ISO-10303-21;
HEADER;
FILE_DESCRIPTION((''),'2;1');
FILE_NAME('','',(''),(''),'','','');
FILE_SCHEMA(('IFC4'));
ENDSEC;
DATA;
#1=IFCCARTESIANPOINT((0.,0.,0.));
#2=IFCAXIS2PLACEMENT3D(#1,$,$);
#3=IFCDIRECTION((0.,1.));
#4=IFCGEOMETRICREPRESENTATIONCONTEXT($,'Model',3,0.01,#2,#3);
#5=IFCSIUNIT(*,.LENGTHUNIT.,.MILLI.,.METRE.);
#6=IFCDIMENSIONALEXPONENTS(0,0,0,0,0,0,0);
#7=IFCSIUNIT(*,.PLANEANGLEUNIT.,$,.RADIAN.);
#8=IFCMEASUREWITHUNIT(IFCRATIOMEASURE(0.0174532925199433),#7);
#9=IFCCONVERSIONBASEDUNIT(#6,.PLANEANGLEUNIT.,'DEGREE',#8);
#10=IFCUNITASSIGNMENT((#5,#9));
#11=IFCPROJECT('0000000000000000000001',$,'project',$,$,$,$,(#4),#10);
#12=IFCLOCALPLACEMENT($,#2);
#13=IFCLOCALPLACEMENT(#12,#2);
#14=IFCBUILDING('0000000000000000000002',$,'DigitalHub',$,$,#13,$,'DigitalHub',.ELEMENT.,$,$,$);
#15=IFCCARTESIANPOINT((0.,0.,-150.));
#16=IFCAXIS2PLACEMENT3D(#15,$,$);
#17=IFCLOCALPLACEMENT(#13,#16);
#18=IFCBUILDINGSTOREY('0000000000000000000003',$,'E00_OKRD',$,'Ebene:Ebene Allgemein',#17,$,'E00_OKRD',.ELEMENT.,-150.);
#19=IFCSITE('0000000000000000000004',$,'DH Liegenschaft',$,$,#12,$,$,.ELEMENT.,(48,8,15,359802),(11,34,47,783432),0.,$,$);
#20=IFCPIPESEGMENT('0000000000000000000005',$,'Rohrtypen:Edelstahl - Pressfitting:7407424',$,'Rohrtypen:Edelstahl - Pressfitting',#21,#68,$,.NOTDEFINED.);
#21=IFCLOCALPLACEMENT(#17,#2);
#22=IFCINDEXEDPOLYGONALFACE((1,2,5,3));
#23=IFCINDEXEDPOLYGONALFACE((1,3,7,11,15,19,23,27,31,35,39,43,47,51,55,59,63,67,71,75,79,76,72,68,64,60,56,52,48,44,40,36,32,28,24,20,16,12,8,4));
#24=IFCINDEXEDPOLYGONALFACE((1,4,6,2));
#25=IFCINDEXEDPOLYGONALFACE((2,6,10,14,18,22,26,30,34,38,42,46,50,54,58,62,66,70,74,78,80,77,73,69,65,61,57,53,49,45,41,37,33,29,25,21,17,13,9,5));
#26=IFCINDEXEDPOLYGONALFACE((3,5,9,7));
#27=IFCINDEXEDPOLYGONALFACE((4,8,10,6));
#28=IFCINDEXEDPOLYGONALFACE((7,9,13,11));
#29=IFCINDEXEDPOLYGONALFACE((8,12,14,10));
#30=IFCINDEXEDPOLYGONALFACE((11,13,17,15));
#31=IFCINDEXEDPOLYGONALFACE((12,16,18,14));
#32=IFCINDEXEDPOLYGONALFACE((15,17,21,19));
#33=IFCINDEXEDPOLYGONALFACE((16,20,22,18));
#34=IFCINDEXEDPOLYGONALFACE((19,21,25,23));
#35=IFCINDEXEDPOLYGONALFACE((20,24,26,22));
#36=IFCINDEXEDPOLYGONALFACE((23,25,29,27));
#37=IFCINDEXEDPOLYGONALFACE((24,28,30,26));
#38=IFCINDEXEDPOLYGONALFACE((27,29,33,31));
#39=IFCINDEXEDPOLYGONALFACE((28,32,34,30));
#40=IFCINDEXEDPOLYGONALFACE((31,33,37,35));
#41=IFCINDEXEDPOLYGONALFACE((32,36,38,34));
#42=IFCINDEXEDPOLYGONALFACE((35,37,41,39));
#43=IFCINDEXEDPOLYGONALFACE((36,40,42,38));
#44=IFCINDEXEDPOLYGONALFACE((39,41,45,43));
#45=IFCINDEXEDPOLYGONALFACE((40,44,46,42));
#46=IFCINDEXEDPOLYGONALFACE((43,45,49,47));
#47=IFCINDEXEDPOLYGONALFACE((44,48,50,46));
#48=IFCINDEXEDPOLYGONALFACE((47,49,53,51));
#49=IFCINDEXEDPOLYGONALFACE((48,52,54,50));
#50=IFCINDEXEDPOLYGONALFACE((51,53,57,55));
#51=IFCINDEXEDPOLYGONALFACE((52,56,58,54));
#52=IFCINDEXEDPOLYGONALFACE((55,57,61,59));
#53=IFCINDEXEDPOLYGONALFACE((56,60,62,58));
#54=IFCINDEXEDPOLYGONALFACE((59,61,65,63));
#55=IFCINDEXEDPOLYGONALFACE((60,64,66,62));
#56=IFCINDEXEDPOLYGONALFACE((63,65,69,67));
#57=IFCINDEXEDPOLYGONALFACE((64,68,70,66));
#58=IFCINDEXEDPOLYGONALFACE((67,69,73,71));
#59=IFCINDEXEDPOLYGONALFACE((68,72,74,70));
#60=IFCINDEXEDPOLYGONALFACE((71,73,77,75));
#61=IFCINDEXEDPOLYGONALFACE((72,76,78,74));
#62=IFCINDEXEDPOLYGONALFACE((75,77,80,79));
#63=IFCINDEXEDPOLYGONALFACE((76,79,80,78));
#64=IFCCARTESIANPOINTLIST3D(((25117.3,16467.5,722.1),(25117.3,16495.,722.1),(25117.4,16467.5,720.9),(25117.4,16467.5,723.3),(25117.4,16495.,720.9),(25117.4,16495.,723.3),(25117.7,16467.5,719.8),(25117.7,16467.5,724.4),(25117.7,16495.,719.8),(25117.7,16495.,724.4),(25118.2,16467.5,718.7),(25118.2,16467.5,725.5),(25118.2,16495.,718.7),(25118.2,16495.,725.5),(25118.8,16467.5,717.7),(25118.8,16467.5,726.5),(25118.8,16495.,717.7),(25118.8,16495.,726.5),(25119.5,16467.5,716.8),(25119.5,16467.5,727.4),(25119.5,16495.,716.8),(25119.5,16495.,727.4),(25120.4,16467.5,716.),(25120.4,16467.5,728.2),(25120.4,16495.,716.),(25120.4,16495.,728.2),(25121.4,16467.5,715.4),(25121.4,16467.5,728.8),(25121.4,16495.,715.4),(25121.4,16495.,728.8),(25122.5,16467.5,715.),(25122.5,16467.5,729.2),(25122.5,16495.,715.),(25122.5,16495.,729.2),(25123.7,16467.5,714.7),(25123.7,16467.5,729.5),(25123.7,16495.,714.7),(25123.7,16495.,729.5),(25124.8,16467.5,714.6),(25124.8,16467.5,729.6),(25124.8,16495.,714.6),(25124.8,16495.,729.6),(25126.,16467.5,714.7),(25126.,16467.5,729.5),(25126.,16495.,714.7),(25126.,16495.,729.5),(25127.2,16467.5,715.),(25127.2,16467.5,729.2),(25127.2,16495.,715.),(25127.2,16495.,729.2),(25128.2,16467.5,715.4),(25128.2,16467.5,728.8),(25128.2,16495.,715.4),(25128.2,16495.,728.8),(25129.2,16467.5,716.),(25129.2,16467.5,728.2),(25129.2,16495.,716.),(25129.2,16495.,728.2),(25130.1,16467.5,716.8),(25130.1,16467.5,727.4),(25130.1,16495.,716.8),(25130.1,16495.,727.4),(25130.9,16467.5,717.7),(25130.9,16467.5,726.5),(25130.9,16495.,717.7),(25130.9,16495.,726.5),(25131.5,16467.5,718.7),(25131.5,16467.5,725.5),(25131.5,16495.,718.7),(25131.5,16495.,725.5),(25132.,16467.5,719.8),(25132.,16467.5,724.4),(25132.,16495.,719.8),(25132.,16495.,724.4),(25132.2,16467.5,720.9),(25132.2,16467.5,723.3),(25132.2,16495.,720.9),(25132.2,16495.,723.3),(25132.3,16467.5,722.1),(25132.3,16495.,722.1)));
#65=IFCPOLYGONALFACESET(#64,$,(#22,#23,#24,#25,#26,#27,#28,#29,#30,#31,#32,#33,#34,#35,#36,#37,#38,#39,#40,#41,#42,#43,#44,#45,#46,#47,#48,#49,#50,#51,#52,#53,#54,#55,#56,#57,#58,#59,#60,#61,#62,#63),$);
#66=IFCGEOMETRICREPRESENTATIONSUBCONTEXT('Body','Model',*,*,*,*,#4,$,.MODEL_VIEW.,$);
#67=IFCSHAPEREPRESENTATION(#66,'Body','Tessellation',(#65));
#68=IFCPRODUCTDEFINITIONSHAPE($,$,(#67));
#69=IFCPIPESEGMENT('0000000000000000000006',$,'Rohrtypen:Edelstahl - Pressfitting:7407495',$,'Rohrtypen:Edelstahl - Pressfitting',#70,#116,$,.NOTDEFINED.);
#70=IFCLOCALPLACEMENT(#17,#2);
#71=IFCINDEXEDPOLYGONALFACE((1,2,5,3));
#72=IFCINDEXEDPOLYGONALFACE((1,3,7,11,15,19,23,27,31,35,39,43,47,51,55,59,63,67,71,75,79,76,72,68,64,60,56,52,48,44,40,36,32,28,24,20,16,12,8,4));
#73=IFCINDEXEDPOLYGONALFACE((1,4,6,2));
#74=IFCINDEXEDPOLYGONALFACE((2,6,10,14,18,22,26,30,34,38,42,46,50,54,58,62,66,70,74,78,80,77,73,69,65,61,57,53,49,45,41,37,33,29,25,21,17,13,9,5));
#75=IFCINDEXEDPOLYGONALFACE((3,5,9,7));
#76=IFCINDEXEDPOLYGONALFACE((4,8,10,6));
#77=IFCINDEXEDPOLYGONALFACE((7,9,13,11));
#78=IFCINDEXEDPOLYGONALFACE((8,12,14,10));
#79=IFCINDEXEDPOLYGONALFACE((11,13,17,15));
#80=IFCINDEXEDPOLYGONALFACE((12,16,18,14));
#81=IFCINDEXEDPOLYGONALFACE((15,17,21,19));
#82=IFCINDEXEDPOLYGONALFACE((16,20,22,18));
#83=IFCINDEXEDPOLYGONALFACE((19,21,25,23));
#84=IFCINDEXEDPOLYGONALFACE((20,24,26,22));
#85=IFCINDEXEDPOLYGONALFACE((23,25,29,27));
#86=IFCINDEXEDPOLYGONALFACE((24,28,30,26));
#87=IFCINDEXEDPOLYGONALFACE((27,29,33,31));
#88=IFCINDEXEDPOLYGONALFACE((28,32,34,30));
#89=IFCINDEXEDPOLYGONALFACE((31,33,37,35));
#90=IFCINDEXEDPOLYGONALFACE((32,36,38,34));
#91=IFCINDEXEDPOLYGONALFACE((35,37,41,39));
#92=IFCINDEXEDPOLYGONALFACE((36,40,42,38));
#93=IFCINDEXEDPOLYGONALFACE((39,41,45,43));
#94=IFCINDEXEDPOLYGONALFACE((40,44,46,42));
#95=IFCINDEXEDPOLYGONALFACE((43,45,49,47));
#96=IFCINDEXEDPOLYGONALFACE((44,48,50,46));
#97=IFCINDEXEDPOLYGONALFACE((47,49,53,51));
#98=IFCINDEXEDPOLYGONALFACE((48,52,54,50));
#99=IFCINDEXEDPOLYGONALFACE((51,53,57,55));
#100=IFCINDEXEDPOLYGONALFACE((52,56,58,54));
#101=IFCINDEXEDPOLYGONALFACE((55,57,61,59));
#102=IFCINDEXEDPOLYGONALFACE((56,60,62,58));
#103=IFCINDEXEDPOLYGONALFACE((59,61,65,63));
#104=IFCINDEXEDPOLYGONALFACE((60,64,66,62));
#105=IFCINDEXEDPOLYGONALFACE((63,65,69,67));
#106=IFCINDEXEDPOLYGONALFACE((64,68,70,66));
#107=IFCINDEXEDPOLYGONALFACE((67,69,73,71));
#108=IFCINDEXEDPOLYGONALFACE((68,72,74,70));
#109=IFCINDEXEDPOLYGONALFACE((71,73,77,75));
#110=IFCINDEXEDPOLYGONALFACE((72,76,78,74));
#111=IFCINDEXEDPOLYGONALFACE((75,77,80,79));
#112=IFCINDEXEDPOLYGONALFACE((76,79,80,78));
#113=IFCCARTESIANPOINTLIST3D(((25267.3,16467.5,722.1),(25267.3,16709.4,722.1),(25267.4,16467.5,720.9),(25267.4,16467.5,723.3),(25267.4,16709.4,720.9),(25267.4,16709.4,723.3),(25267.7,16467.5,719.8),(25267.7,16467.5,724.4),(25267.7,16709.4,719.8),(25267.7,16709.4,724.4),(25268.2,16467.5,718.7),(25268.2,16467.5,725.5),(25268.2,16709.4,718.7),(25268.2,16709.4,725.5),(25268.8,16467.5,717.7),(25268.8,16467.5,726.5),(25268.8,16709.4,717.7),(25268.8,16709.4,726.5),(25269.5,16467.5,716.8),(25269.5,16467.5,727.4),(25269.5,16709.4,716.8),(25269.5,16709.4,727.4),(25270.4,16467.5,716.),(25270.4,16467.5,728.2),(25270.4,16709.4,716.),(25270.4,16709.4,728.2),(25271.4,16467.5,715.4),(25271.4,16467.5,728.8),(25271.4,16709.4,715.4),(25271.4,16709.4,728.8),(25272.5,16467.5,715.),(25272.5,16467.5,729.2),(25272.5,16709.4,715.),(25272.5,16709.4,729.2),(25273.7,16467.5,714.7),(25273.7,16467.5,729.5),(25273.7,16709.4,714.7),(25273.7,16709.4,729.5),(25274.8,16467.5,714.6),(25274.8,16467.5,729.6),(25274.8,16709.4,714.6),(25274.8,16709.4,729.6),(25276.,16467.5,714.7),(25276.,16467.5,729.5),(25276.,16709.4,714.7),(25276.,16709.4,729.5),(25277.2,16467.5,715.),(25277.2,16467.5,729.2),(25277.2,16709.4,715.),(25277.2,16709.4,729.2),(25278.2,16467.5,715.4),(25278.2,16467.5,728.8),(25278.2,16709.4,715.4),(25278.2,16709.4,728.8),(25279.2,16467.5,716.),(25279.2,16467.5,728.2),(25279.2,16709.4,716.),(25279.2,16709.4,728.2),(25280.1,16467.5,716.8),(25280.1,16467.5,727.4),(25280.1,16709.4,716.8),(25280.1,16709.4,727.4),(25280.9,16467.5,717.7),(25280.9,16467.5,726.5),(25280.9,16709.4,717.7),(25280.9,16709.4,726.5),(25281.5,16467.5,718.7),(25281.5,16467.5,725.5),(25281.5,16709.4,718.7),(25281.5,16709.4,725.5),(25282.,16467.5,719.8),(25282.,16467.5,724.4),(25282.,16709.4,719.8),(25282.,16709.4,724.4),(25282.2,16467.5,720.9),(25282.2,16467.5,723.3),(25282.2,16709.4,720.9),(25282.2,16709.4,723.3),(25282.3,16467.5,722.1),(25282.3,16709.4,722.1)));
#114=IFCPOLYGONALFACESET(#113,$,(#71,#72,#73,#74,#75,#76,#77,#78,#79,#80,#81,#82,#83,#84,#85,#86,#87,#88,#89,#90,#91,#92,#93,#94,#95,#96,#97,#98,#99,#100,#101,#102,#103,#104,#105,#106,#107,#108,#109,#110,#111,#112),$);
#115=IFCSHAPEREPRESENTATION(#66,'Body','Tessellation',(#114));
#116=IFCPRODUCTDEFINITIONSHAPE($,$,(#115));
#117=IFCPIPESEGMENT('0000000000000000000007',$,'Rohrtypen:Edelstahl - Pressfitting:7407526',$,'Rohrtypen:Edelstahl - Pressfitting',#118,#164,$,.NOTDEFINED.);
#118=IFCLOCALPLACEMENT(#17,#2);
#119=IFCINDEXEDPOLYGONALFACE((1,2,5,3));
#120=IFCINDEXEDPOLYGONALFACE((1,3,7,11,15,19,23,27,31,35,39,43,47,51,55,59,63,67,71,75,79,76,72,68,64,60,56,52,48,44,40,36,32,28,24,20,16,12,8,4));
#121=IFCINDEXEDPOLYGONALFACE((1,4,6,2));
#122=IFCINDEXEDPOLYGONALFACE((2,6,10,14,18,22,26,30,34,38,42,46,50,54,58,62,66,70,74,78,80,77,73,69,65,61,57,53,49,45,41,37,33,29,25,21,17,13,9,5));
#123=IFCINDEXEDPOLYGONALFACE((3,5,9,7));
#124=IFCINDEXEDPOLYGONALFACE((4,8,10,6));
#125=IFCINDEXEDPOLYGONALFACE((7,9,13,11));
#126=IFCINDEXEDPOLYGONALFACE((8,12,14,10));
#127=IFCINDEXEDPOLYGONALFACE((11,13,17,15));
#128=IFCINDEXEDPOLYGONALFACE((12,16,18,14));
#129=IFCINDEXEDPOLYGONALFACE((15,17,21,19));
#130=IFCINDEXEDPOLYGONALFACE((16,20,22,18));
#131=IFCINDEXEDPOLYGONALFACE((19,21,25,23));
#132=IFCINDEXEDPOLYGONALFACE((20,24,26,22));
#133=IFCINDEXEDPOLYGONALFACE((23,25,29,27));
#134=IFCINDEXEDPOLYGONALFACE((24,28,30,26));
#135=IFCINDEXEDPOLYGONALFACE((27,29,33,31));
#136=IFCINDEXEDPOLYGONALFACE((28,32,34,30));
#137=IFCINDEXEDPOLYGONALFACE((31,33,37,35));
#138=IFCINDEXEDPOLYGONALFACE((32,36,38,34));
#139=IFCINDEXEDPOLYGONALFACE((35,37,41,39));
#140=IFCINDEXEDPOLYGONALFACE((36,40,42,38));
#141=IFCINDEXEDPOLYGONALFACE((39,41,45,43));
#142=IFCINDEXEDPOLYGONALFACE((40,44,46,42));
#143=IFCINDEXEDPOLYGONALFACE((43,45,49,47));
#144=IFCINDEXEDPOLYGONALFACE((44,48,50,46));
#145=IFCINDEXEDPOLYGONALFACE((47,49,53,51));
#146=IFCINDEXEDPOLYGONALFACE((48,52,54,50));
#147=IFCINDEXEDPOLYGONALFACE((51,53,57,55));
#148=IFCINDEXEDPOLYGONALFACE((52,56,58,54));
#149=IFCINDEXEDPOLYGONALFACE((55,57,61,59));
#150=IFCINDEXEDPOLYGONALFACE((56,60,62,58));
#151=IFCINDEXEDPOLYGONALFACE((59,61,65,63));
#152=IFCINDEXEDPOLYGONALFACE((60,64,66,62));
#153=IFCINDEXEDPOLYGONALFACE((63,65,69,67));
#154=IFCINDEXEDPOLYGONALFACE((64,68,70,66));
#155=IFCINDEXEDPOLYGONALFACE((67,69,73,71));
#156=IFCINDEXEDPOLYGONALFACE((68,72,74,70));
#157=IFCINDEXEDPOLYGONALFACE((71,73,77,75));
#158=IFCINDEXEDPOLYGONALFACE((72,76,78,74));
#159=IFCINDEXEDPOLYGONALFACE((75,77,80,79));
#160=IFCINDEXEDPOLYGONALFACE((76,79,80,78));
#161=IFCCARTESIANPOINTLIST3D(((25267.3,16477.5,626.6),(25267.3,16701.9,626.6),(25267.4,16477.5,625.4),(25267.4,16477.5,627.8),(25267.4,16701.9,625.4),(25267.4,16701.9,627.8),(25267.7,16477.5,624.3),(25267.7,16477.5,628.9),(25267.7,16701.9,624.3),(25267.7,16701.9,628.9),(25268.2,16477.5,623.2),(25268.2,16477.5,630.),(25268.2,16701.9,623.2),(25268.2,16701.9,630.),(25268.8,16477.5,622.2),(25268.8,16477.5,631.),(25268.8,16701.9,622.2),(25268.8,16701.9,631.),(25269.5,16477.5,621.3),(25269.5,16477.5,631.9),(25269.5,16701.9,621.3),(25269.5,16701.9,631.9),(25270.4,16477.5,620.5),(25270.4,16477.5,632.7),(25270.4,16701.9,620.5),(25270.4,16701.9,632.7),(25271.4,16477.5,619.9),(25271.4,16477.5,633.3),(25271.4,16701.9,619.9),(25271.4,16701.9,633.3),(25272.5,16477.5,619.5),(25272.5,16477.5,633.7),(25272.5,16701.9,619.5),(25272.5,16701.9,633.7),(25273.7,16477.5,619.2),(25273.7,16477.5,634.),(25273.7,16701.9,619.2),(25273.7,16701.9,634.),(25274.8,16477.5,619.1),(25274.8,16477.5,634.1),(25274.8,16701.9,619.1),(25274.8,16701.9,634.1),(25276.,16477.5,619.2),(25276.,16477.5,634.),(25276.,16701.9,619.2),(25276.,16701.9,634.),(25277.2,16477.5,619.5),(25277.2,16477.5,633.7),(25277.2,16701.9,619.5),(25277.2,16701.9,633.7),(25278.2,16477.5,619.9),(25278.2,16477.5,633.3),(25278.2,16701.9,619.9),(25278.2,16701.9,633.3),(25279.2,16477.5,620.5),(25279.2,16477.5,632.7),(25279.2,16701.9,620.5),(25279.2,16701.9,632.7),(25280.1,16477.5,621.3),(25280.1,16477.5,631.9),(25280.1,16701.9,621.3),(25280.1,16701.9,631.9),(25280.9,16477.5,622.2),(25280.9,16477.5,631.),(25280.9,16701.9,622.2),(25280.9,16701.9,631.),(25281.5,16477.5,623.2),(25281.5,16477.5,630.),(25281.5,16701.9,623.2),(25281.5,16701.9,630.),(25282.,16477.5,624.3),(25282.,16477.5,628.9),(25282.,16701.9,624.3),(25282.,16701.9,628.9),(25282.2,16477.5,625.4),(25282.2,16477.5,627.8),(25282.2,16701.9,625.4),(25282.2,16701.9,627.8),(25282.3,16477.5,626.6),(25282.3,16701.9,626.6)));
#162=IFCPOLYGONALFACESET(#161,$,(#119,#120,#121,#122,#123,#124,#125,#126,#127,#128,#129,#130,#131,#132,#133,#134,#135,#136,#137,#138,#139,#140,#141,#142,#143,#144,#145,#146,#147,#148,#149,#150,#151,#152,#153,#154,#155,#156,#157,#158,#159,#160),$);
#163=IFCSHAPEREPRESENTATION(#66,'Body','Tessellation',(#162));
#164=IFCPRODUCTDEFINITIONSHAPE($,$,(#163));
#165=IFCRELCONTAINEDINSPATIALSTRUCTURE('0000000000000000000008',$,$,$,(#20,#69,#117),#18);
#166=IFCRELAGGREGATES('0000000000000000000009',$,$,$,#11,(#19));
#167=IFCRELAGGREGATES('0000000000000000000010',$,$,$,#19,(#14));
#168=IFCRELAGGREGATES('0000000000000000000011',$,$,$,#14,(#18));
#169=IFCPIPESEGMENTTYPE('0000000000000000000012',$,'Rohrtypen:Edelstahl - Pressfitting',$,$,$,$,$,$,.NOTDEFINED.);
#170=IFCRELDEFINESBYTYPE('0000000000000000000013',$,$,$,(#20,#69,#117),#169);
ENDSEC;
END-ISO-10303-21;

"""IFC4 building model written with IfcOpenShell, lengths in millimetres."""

from ifc_helpers import new_model, entity, si_unit, converted_unit, direction, frame, origin, place, context, subcontext, project, spatial, indexed_curve, outline, extrude, type_object, element, save


model = new_model("IFC4")

# Units and contexts
model_context = context("Model", 3, precision=0.01, world=origin(), true_north=direction((0.0, 1.0)))
body_context = subcontext(model_context, "Body", "Model", "MODEL_VIEW")
ifc_project = project(units=[si_unit("LENGTHUNIT", "METRE", prefix="MILLI"), converted_unit("PLANEANGLEUNIT", "DEGREE", entity("IfcRatioMeasure", 0.0174532925199433), si_unit("PLANEANGLEUNIT", "RADIAN"), dimensions=[0, 0, 0, 0, 0, 0, 0])], contexts=[model_context])

# Site, building, storey
site_placement = place(None, origin())
site = spatial("IfcSite", under=ifc_project, at=site_placement, Name="DH Liegenschaft", CompositionType="ELEMENT", RefLatitude=(48, 8, 15, 359802), RefLongitude=(11, 34, 47, 783432), RefElevation=0.0)
building_placement = place(site_placement, origin())
building = spatial("IfcBuilding", under=site, at=building_placement, Name="DigitalHub", LongName="DigitalHub", CompositionType="ELEMENT")
storey_placement = place(building_placement, frame((0.0, 0.0, -150.0)))
storey = spatial("IfcBuildingStorey", under=building, at=storey_placement, Name="E00_OKRD", ObjectType="Ebene:Ebene Allgemein", LongName="E00_OKRD", CompositionType="ELEMENT", Elevation=-150.0)

# Pipe segments
pipe_segment_type_1 = type_object("IfcPipeSegmentType", Name="Rohrtypen:Edelstahl - Pressfitting", PredefinedType="NOTDEFINED")
pipe_segment_1_placement = place(storey_placement, frame((25115.7, 16467.5, 713.0)))
element("IfcPipeSegment", 1, at=pipe_segment_1_placement, inside=storey, type_object=pipe_segment_type_1, Name="Rohrtypen:Edelstahl - Pressfitting:7407424", ObjectType="Rohrtypen:Edelstahl - Pressfitting", PredefinedType="NOTDEFINED", context=body_context, shape_type="SweptSolid", body=[
    extrude(outline(indexed_curve([(7.5, 0.0), (7.4, 1.2), (7.1, 2.3), (6.7, 3.4), (6.1, 4.4), (5.3, 5.3), (4.4, 6.1), (3.4, 6.7), (2.3, 7.1), (1.2, 7.4), (0.0, 7.5), (-1.2, 7.4), (-2.3, 7.1), (-3.4, 6.7), (-4.4, 6.1), (-5.3, 5.3), (-6.1, 4.4), (-6.7, 3.4), (-7.1, 2.3), (-7.4, 1.2), (-7.5, 0.0), (-7.4, -1.2), (-7.1, -2.3), (-6.7, -3.4), (-6.1, -4.4), (-5.3, -5.3), (-4.4, -6.1), (-3.4, -6.7), (-2.3, -7.1), (-1.2, -7.4), (0.0, -7.5), (1.2, -7.4), (2.3, -7.1), (3.4, -6.7), (4.4, -6.1), (5.3, -5.3), (6.1, -4.4), (6.7, -3.4), (7.1, -2.3), (7.4, -1.2), (7.5, 0.0)], self_intersect=False)), frame((9.1, 0.0, 9.1), z_axis=(0.0, 1.0, 0.0), x_axis=(1.0, 0.0, 0.0)), (0.0, 0.0, 1.0), 27.4),
])
pipe_segment_2_placement = place(storey_placement, frame((25265.7, 16467.5, 713.0)))
element("IfcPipeSegment", 2, at=pipe_segment_2_placement, inside=storey, type_object=pipe_segment_type_1, Name="Rohrtypen:Edelstahl - Pressfitting:7407495", ObjectType="Rohrtypen:Edelstahl - Pressfitting", PredefinedType="NOTDEFINED", context=body_context, shape_type="SweptSolid", body=[
    extrude(outline(indexed_curve([(7.5, 0.0), (7.4, 1.2), (7.1, 2.3), (6.7, 3.4), (6.1, 4.4), (5.3, 5.3), (4.4, 6.1), (3.4, 6.7), (2.3, 7.1), (1.2, 7.4), (0.0, 7.5), (-1.2, 7.4), (-2.3, 7.1), (-3.4, 6.7), (-4.4, 6.1), (-5.3, 5.3), (-6.1, 4.4), (-6.7, 3.4), (-7.1, 2.3), (-7.4, 1.2), (-7.5, 0.0), (-7.4, -1.2), (-7.1, -2.3), (-6.7, -3.4), (-6.1, -4.4), (-5.3, -5.3), (-4.4, -6.1), (-3.4, -6.7), (-2.3, -7.1), (-1.2, -7.4), (0.0, -7.5), (1.2, -7.4), (2.3, -7.1), (3.4, -6.7), (4.4, -6.1), (5.3, -5.3), (6.1, -4.4), (6.7, -3.4), (7.1, -2.3), (7.4, -1.2), (7.5, 0.0)], self_intersect=False)), frame((9.1, 0.0, 9.1), z_axis=(0.0, 1.0, 0.0), x_axis=(1.0, 0.0, 0.0)), (0.0, 0.0, 1.0), 241.9),
])
pipe_segment_3_placement = place(storey_placement, frame((25265.7, 16477.5, 617.5)))
element("IfcPipeSegment", 3, at=pipe_segment_3_placement, inside=storey, type_object=pipe_segment_type_1, Name="Rohrtypen:Edelstahl - Pressfitting:7407526", ObjectType="Rohrtypen:Edelstahl - Pressfitting", PredefinedType="NOTDEFINED", context=body_context, shape_type="SweptSolid", body=[
    extrude(outline(indexed_curve([(7.5, 0.0), (7.4, 1.2), (7.1, 2.3), (6.7, 3.4), (6.1, 4.4), (5.3, 5.3), (4.4, 6.1), (3.4, 6.7), (2.3, 7.1), (1.2, 7.4), (0.0, 7.5), (-1.2, 7.4), (-2.3, 7.1), (-3.4, 6.7), (-4.4, 6.1), (-5.3, 5.3), (-6.1, 4.4), (-6.7, 3.4), (-7.1, 2.3), (-7.4, 1.2), (-7.5, 0.0), (-7.4, -1.2), (-7.1, -2.3), (-6.7, -3.4), (-6.1, -4.4), (-5.3, -5.3), (-4.4, -6.1), (-3.4, -6.7), (-2.3, -7.1), (-1.2, -7.4), (0.0, -7.5), (1.2, -7.4), (2.3, -7.1), (3.4, -6.7), (4.4, -6.1), (5.3, -5.3), (6.1, -4.4), (6.7, -3.4), (7.1, -2.3), (7.4, -1.2), (7.5, 0.0)], self_intersect=False)), frame((9.1, 224.4, 9.1), z_axis=(0.000016, -1.0, 0.0), x_axis=(1.0, 0.000016, 0.0)), (0.0, 0.0, 1.0), 224.4),
])

save(model, "model.ifc")
